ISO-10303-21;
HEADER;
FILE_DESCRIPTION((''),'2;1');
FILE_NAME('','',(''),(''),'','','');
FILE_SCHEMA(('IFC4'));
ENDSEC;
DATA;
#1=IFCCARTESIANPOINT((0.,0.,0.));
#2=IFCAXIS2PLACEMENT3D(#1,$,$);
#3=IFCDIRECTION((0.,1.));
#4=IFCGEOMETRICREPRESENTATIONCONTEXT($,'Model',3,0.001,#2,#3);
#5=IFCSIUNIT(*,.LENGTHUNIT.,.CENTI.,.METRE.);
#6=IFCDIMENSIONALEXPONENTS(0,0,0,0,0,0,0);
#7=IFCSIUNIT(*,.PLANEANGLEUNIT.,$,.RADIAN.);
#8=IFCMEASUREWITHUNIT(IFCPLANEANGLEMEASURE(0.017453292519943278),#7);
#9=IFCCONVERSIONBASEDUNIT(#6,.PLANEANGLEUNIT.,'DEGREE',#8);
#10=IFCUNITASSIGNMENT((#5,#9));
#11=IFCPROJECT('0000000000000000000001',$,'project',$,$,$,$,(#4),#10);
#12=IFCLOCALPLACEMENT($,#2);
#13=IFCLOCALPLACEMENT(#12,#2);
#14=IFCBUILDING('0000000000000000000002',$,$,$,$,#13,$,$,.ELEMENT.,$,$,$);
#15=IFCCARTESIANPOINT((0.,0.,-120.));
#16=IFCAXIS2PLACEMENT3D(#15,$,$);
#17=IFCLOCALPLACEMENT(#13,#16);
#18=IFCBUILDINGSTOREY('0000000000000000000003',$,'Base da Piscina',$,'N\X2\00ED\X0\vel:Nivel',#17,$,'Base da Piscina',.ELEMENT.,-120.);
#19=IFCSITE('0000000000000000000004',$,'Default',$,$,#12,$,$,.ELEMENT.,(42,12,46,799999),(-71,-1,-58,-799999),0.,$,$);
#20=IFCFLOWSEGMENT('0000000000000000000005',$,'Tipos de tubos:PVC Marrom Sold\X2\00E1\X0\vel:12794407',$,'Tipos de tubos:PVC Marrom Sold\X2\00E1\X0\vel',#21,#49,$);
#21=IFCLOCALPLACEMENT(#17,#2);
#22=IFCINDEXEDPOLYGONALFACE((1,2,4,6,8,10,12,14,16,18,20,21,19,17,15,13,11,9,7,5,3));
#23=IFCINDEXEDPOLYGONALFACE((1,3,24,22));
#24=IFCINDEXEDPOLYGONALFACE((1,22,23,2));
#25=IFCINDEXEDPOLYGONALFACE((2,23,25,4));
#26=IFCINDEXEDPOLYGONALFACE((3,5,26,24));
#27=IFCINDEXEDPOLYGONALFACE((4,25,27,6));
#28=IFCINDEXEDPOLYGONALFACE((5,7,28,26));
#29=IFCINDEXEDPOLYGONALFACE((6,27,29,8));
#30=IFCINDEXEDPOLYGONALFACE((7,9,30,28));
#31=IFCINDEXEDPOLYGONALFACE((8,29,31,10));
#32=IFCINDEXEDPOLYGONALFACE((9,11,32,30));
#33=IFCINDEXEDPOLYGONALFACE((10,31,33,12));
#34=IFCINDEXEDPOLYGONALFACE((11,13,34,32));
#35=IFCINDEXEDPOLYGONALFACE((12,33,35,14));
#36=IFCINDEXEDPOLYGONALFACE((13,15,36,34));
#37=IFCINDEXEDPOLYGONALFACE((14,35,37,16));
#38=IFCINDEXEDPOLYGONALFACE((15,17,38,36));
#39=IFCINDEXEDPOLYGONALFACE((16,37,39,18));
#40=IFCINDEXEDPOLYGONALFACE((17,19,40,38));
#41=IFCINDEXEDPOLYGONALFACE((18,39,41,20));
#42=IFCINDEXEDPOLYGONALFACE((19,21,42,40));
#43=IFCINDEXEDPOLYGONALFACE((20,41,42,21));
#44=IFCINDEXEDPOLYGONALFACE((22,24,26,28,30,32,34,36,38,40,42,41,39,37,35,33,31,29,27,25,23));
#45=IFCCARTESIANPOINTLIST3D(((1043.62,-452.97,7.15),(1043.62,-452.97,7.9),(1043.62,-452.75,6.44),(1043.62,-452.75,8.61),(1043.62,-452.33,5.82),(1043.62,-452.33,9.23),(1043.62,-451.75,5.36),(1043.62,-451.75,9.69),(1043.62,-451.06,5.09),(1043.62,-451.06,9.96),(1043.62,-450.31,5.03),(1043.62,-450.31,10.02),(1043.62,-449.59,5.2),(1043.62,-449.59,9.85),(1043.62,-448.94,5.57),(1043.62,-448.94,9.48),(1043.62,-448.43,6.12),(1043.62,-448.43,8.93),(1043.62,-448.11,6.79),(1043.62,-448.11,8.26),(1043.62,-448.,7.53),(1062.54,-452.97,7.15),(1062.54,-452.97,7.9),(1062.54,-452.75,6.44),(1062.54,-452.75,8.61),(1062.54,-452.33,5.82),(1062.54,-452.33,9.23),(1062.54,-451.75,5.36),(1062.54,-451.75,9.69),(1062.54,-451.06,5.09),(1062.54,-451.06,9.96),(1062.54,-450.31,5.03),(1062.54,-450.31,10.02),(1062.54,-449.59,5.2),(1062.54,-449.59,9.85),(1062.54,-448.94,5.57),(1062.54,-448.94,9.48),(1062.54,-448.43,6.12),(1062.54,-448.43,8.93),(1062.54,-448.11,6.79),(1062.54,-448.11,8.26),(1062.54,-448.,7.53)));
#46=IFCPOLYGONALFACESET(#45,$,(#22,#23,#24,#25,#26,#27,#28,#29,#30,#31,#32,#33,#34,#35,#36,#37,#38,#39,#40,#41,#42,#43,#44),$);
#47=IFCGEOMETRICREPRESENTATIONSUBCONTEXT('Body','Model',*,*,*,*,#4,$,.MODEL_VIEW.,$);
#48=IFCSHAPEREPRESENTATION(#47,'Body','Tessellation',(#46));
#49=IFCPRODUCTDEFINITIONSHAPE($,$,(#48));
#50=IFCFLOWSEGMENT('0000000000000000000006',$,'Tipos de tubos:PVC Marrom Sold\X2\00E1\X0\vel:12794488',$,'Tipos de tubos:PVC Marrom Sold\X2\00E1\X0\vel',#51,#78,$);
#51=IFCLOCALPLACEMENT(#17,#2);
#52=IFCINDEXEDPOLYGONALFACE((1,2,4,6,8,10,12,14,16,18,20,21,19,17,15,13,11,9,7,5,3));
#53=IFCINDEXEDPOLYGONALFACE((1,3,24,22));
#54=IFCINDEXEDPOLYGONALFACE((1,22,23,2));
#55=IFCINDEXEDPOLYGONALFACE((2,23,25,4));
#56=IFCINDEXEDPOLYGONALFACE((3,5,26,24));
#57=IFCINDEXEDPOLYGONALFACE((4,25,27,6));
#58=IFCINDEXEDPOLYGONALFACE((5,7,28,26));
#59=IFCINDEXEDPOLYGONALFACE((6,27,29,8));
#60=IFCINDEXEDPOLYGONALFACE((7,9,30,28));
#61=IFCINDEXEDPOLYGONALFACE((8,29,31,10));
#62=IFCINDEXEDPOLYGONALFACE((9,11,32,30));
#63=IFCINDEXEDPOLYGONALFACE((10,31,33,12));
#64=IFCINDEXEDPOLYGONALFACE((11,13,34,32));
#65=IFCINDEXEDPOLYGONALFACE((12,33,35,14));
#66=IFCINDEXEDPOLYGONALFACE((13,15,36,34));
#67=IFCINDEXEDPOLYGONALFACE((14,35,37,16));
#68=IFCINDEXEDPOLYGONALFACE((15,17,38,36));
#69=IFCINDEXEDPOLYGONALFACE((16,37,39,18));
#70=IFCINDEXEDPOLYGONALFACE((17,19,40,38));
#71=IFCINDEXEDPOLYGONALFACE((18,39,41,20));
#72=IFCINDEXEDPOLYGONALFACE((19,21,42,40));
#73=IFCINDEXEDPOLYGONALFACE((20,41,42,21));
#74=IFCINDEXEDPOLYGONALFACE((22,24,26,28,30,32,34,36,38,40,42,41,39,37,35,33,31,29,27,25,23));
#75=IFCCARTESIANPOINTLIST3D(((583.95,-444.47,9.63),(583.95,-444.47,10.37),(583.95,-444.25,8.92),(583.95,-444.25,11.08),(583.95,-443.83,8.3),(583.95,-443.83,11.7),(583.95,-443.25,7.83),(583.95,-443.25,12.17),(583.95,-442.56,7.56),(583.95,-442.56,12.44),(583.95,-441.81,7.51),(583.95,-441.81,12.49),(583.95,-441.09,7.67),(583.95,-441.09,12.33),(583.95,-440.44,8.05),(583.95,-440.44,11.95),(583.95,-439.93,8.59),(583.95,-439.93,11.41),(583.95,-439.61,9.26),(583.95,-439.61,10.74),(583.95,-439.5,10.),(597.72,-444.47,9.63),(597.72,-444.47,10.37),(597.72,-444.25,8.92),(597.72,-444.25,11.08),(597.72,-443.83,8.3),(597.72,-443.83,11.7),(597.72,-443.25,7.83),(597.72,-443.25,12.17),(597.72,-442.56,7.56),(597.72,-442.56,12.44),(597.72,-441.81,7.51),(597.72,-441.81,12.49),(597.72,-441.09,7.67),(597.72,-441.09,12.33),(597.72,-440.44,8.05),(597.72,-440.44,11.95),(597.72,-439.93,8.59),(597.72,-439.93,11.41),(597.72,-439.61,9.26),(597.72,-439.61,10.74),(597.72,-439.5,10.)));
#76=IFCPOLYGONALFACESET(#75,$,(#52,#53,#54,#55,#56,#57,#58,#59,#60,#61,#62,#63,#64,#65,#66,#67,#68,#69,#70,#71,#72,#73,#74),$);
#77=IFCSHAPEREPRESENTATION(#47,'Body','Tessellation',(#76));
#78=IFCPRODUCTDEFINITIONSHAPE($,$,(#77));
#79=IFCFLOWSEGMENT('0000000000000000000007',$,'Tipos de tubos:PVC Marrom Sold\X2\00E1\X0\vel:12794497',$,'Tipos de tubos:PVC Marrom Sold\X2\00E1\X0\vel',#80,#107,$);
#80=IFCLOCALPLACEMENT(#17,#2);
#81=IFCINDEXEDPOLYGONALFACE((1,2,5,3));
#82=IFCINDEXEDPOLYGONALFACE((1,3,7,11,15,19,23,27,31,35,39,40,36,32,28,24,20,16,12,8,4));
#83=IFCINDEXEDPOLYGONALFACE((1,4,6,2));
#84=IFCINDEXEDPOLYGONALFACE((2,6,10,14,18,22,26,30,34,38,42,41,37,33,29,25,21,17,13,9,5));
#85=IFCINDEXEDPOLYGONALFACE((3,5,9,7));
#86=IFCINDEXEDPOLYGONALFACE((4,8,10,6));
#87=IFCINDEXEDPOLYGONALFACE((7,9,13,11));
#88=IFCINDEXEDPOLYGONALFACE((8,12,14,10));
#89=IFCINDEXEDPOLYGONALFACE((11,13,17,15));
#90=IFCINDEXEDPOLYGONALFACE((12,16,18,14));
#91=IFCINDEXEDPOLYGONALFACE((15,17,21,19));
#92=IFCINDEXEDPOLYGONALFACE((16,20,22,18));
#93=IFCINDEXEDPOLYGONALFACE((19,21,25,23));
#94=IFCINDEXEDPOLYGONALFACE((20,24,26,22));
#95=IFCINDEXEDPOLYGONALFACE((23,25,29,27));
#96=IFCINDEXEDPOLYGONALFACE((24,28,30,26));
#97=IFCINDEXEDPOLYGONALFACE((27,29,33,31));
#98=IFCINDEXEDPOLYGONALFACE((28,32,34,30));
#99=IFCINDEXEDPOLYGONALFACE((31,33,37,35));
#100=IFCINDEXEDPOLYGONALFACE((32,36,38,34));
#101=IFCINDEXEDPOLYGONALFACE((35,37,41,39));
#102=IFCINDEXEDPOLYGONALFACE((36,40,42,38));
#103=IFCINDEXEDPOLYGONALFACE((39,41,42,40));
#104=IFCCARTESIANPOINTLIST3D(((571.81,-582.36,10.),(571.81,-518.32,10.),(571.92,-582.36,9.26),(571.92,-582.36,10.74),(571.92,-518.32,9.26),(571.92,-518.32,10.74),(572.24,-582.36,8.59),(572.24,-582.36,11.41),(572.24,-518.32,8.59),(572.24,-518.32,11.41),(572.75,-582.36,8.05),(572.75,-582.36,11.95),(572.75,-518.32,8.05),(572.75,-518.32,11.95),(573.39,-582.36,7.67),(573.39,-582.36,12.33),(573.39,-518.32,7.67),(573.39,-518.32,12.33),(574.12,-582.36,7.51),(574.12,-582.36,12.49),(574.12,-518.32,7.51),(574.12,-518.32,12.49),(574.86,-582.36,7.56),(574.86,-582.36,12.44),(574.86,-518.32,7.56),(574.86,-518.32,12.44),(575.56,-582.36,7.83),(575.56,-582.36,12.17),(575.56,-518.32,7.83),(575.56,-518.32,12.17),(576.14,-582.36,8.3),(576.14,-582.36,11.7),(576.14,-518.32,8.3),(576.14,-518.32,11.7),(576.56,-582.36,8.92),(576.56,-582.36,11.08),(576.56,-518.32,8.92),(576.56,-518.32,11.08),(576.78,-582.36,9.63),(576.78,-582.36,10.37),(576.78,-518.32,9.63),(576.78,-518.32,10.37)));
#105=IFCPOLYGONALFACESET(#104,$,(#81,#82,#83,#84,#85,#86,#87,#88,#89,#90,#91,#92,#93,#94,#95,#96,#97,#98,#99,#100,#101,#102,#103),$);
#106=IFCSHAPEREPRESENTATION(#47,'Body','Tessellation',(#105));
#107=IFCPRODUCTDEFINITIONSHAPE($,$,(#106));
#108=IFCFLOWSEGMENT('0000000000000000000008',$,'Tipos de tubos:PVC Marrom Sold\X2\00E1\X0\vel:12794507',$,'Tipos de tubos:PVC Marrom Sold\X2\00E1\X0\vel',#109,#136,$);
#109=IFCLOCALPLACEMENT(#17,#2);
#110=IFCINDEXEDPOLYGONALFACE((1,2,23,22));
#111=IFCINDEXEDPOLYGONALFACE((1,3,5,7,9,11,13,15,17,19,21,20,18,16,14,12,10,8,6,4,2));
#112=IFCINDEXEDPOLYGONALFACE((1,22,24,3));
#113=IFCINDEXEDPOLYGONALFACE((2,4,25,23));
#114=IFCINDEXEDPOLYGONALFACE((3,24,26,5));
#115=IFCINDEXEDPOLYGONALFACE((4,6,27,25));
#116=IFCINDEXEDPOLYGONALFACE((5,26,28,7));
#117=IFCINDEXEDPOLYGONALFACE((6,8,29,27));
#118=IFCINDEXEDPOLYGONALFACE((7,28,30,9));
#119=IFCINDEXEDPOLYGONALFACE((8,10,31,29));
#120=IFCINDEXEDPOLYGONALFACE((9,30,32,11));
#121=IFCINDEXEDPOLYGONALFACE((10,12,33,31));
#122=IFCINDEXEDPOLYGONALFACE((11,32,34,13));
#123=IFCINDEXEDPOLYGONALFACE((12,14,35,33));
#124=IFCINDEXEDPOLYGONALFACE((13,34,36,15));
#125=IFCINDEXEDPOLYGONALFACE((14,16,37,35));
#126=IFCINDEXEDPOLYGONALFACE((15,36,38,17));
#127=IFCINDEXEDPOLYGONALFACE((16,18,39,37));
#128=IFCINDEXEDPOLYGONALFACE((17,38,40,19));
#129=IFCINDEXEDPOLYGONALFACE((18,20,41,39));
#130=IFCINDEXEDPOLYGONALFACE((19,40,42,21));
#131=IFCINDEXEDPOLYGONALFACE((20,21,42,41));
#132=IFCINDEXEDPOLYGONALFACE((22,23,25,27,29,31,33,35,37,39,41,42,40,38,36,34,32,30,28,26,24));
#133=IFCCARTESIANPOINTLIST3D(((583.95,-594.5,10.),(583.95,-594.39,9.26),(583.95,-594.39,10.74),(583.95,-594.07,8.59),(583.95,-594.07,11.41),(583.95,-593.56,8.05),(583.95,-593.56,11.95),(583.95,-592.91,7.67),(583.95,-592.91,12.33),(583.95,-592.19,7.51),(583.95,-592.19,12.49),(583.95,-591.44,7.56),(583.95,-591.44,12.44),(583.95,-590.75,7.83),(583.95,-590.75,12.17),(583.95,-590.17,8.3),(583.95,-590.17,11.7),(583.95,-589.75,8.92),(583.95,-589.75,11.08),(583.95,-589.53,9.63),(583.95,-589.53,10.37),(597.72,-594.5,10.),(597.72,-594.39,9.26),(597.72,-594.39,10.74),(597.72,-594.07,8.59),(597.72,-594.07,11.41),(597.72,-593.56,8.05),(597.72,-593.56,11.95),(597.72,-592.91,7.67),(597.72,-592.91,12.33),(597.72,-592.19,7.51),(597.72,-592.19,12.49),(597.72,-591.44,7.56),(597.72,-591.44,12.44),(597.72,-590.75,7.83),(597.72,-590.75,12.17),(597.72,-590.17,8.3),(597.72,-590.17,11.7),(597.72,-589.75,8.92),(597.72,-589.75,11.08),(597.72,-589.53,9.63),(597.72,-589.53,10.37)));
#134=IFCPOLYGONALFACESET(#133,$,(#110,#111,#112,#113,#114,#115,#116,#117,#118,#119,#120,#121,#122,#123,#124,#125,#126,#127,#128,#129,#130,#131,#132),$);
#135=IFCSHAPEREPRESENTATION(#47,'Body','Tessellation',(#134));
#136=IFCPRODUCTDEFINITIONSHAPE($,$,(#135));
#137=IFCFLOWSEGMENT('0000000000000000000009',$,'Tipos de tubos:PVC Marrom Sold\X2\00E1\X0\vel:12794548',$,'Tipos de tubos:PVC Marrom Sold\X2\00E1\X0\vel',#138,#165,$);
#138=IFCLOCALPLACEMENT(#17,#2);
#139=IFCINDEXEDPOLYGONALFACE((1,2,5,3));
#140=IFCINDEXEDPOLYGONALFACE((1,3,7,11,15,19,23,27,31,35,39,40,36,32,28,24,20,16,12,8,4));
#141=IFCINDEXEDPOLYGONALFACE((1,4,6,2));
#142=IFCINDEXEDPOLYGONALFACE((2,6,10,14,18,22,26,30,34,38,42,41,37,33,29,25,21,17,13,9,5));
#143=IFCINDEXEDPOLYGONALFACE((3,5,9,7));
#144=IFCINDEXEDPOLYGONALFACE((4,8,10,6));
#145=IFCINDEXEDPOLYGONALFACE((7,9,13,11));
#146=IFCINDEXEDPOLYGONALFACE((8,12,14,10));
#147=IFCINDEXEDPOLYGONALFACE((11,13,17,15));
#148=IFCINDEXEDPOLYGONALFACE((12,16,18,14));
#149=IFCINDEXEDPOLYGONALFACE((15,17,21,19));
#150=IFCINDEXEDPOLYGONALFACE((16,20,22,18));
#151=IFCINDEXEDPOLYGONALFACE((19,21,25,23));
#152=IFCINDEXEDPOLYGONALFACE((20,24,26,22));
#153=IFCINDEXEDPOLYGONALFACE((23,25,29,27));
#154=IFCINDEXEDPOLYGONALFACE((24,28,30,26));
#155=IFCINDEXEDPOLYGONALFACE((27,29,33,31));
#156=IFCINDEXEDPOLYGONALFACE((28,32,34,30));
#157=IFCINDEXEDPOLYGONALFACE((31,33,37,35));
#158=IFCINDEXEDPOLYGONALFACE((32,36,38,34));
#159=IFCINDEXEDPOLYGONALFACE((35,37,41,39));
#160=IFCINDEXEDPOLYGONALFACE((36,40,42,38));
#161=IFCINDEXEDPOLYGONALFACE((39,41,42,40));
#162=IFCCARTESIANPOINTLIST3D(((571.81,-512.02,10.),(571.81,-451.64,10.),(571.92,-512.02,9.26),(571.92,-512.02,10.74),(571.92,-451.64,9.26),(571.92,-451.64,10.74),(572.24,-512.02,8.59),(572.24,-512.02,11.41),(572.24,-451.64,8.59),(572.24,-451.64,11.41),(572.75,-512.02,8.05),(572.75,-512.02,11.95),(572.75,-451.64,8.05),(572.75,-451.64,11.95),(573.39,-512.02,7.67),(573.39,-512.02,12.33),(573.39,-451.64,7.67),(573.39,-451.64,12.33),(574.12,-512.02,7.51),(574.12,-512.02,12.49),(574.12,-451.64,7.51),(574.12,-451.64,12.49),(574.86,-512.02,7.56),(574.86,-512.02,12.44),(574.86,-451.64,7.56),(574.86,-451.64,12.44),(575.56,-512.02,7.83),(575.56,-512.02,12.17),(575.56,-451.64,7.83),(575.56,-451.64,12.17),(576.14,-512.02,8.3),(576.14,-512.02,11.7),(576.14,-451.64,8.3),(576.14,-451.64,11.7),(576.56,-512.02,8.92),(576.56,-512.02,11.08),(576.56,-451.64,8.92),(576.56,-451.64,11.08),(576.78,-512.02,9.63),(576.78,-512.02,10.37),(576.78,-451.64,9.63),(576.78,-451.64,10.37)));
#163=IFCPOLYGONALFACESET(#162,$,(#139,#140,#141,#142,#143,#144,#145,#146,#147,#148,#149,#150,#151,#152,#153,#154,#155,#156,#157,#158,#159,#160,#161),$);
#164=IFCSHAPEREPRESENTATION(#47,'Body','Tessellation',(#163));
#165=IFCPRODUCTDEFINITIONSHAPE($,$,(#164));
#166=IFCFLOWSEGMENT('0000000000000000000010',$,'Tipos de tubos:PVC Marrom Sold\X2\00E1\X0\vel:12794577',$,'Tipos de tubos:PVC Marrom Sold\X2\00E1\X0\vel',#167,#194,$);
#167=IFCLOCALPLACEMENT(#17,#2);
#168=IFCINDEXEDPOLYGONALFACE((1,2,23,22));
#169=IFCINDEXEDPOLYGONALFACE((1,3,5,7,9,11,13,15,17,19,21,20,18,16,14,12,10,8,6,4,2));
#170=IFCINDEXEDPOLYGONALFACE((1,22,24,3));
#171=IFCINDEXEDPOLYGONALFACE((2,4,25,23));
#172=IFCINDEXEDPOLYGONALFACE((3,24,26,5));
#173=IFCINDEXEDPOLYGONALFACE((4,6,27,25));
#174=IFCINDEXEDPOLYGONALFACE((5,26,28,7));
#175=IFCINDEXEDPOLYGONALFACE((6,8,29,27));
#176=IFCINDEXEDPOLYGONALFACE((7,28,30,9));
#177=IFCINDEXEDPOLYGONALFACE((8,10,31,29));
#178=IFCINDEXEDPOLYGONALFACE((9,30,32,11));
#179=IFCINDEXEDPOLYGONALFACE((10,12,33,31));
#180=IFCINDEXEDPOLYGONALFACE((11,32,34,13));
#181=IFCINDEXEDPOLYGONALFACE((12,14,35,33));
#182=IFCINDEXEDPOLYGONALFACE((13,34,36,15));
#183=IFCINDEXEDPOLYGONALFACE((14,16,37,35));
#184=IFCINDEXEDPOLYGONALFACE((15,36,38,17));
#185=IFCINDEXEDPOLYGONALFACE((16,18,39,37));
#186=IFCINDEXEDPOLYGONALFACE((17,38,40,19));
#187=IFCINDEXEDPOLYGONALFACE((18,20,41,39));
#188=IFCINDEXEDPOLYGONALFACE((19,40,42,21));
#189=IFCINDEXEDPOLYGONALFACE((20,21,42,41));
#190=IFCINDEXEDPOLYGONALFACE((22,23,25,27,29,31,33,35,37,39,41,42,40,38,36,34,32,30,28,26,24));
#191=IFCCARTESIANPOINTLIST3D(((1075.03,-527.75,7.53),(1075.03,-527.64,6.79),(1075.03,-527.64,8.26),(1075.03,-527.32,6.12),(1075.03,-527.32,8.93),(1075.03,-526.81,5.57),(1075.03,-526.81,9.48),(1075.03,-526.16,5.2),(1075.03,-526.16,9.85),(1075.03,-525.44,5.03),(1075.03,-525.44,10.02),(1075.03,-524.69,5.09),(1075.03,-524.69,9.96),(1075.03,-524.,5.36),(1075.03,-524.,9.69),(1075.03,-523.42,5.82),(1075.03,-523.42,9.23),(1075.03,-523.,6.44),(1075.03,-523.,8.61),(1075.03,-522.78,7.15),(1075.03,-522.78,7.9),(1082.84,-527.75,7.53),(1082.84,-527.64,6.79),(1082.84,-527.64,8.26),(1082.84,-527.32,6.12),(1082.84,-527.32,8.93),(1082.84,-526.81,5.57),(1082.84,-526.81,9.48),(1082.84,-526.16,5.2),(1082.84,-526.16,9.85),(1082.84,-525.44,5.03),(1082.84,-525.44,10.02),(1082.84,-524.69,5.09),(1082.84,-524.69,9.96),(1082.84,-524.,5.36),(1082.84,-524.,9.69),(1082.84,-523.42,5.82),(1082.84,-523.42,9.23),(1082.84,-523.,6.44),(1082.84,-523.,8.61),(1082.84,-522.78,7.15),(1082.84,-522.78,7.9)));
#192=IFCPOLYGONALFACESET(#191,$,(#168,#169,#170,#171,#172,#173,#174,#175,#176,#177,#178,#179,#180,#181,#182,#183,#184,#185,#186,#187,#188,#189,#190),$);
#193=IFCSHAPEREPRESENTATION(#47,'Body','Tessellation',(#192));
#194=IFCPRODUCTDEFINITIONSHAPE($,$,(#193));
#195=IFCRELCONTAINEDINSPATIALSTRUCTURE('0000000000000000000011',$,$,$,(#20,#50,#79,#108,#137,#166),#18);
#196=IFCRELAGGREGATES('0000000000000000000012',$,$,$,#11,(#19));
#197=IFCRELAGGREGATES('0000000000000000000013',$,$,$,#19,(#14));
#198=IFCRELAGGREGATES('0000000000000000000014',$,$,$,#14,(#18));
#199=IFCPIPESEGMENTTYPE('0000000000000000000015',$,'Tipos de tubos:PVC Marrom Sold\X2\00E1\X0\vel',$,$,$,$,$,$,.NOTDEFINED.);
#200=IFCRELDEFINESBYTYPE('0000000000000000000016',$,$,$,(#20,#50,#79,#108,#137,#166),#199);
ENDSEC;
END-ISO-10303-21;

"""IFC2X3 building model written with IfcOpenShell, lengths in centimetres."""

from ifc_helpers import new_model, entity, si_unit, converted_unit, direction, frame, frame_2d, origin, origin_2d_with_axis, place, context, subcontext, project, spatial, circle, extrude, type_object, element, save


model = new_model("IFC2X3")

# Units and contexts
model_context = context("Model", 3, precision=0.001, world=origin(), true_north=direction((0.0, 1.0)))
body_context = subcontext(model_context, "Body", "Model", "MODEL_VIEW")
ifc_project = project(units=[si_unit("LENGTHUNIT", "METRE", prefix="CENTI"), converted_unit("PLANEANGLEUNIT", "DEGREE", entity("IfcPlaneAngleMeasure", 0.017453292519943278), si_unit("PLANEANGLEUNIT", "RADIAN"), dimensions=[0, 0, 0, 0, 0, 0, 0])], contexts=[model_context])

# Site, building, storey
site_placement = place(None, origin())
site = spatial("IfcSite", under=ifc_project, at=site_placement, Name="Default", CompositionType="ELEMENT", RefLatitude=(42, 12, 46, 799999), RefLongitude=(-71, -1, -58, -799999), RefElevation=0.0)
building_placement = place(site_placement, origin())
building = spatial("IfcBuilding", under=site, at=building_placement, CompositionType="ELEMENT")
storey_placement = place(building_placement, frame((0.0, 0.0, -120.0)))
storey = spatial("IfcBuildingStorey", under=building, at=storey_placement, Name="Base da Piscina", ObjectType="Nível:Nivel", LongName="Base da Piscina", CompositionType="ELEMENT", Elevation=-120.0)

# Flow segments
pipe_segment_type = type_object("IfcPipeSegmentType", Name="Tipos de tubos:PVC Marrom Soldável", PredefinedType="NOTDEFINED")
flow_segment_1_placement = place(storey_placement, origin())
element("IfcFlowSegment", 1, at=flow_segment_1_placement, inside=storey, type_object=pipe_segment_type, Name="Tipos de tubos:PVC Marrom Soldável:12794407", ObjectType="Tipos de tubos:PVC Marrom Soldável", context=body_context, shape_type="SweptSolid", body=[
    extrude(circle(Radius=2.5, at=origin_2d_with_axis()), frame((1043.62, -450.5, 7.53), z_axis=(1.0, 0.0, 0.0), x_axis=(0.0, 1.0, 0.0)), (0.0, 0.0, 1.0), 18.91),
])
flow_segment_2_placement = place(storey_placement, origin())
element("IfcFlowSegment", 2, at=flow_segment_2_placement, inside=storey, type_object=pipe_segment_type, Name="Tipos de tubos:PVC Marrom Soldável:12794488", ObjectType="Tipos de tubos:PVC Marrom Soldável", context=body_context, shape_type="SweptSolid", body=[
    extrude(circle(Radius=2.5, at=origin_2d_with_axis()), frame((583.95, -442.0, 10.0), z_axis=(1.0, 0.0, 0.0), x_axis=(0.0, 1.0, 0.0)), (0.0, 0.0, 1.0), 13.77),
])
flow_segment_3_placement = place(storey_placement, origin())
element("IfcFlowSegment", 3, at=flow_segment_3_placement, inside=storey, type_object=pipe_segment_type, Name="Tipos de tubos:PVC Marrom Soldável:12794497", ObjectType="Tipos de tubos:PVC Marrom Soldável", context=body_context, shape_type="SweptSolid", body=[
    extrude(circle(Radius=2.5, at=frame_2d((0.0, 0.0), x_axis=(1.0, 0.0))), frame((574.31, -582.36, 10.0), z_axis=(0.0, 1.0, 0.0), x_axis=(-1.0, 0.0, 0.0)), (0.0, 0.0, 1.0), 64.04),
])
flow_segment_4_placement = place(storey_placement, origin())
element("IfcFlowSegment", 4, at=flow_segment_4_placement, inside=storey, type_object=pipe_segment_type, Name="Tipos de tubos:PVC Marrom Soldável:12794507", ObjectType="Tipos de tubos:PVC Marrom Soldável", context=body_context, shape_type="SweptSolid", body=[
    extrude(circle(Radius=2.5, at=origin_2d_with_axis()), frame((583.95, -592.0, 10.0), z_axis=(1.0, 0.0, 0.0), x_axis=(0.0, -1.0, 0.0)), (0.0, 0.0, 1.0), 13.77),
])
flow_segment_5_placement = place(storey_placement, origin())
element("IfcFlowSegment", 5, at=flow_segment_5_placement, inside=storey, type_object=pipe_segment_type, Name="Tipos de tubos:PVC Marrom Soldável:12794548", ObjectType="Tipos de tubos:PVC Marrom Soldável", context=body_context, shape_type="SweptSolid", body=[
    extrude(circle(Radius=2.5, at=frame_2d((0.0, 0.0), x_axis=(1.0, 0.0))), frame((574.31, -512.02, 10.0), z_axis=(0.0, 1.0, 0.0), x_axis=(-1.0, 0.0, 0.0)), (0.0, 0.0, 1.0), 60.37),
])
flow_segment_6_placement = place(storey_placement, origin())
element("IfcFlowSegment", 6, at=flow_segment_6_placement, inside=storey, type_object=pipe_segment_type, Name="Tipos de tubos:PVC Marrom Soldável:12794577", ObjectType="Tipos de tubos:PVC Marrom Soldável", context=body_context, shape_type="SweptSolid", body=[
    extrude(circle(Radius=2.5, at=origin_2d_with_axis()), frame((1075.03, -525.25, 7.53), z_axis=(1.0, 0.0, 0.0), x_axis=(0.0, -1.0, 0.0)), (0.0, 0.0, 1.0), 7.81),
])

save(model, "model.ifc")
